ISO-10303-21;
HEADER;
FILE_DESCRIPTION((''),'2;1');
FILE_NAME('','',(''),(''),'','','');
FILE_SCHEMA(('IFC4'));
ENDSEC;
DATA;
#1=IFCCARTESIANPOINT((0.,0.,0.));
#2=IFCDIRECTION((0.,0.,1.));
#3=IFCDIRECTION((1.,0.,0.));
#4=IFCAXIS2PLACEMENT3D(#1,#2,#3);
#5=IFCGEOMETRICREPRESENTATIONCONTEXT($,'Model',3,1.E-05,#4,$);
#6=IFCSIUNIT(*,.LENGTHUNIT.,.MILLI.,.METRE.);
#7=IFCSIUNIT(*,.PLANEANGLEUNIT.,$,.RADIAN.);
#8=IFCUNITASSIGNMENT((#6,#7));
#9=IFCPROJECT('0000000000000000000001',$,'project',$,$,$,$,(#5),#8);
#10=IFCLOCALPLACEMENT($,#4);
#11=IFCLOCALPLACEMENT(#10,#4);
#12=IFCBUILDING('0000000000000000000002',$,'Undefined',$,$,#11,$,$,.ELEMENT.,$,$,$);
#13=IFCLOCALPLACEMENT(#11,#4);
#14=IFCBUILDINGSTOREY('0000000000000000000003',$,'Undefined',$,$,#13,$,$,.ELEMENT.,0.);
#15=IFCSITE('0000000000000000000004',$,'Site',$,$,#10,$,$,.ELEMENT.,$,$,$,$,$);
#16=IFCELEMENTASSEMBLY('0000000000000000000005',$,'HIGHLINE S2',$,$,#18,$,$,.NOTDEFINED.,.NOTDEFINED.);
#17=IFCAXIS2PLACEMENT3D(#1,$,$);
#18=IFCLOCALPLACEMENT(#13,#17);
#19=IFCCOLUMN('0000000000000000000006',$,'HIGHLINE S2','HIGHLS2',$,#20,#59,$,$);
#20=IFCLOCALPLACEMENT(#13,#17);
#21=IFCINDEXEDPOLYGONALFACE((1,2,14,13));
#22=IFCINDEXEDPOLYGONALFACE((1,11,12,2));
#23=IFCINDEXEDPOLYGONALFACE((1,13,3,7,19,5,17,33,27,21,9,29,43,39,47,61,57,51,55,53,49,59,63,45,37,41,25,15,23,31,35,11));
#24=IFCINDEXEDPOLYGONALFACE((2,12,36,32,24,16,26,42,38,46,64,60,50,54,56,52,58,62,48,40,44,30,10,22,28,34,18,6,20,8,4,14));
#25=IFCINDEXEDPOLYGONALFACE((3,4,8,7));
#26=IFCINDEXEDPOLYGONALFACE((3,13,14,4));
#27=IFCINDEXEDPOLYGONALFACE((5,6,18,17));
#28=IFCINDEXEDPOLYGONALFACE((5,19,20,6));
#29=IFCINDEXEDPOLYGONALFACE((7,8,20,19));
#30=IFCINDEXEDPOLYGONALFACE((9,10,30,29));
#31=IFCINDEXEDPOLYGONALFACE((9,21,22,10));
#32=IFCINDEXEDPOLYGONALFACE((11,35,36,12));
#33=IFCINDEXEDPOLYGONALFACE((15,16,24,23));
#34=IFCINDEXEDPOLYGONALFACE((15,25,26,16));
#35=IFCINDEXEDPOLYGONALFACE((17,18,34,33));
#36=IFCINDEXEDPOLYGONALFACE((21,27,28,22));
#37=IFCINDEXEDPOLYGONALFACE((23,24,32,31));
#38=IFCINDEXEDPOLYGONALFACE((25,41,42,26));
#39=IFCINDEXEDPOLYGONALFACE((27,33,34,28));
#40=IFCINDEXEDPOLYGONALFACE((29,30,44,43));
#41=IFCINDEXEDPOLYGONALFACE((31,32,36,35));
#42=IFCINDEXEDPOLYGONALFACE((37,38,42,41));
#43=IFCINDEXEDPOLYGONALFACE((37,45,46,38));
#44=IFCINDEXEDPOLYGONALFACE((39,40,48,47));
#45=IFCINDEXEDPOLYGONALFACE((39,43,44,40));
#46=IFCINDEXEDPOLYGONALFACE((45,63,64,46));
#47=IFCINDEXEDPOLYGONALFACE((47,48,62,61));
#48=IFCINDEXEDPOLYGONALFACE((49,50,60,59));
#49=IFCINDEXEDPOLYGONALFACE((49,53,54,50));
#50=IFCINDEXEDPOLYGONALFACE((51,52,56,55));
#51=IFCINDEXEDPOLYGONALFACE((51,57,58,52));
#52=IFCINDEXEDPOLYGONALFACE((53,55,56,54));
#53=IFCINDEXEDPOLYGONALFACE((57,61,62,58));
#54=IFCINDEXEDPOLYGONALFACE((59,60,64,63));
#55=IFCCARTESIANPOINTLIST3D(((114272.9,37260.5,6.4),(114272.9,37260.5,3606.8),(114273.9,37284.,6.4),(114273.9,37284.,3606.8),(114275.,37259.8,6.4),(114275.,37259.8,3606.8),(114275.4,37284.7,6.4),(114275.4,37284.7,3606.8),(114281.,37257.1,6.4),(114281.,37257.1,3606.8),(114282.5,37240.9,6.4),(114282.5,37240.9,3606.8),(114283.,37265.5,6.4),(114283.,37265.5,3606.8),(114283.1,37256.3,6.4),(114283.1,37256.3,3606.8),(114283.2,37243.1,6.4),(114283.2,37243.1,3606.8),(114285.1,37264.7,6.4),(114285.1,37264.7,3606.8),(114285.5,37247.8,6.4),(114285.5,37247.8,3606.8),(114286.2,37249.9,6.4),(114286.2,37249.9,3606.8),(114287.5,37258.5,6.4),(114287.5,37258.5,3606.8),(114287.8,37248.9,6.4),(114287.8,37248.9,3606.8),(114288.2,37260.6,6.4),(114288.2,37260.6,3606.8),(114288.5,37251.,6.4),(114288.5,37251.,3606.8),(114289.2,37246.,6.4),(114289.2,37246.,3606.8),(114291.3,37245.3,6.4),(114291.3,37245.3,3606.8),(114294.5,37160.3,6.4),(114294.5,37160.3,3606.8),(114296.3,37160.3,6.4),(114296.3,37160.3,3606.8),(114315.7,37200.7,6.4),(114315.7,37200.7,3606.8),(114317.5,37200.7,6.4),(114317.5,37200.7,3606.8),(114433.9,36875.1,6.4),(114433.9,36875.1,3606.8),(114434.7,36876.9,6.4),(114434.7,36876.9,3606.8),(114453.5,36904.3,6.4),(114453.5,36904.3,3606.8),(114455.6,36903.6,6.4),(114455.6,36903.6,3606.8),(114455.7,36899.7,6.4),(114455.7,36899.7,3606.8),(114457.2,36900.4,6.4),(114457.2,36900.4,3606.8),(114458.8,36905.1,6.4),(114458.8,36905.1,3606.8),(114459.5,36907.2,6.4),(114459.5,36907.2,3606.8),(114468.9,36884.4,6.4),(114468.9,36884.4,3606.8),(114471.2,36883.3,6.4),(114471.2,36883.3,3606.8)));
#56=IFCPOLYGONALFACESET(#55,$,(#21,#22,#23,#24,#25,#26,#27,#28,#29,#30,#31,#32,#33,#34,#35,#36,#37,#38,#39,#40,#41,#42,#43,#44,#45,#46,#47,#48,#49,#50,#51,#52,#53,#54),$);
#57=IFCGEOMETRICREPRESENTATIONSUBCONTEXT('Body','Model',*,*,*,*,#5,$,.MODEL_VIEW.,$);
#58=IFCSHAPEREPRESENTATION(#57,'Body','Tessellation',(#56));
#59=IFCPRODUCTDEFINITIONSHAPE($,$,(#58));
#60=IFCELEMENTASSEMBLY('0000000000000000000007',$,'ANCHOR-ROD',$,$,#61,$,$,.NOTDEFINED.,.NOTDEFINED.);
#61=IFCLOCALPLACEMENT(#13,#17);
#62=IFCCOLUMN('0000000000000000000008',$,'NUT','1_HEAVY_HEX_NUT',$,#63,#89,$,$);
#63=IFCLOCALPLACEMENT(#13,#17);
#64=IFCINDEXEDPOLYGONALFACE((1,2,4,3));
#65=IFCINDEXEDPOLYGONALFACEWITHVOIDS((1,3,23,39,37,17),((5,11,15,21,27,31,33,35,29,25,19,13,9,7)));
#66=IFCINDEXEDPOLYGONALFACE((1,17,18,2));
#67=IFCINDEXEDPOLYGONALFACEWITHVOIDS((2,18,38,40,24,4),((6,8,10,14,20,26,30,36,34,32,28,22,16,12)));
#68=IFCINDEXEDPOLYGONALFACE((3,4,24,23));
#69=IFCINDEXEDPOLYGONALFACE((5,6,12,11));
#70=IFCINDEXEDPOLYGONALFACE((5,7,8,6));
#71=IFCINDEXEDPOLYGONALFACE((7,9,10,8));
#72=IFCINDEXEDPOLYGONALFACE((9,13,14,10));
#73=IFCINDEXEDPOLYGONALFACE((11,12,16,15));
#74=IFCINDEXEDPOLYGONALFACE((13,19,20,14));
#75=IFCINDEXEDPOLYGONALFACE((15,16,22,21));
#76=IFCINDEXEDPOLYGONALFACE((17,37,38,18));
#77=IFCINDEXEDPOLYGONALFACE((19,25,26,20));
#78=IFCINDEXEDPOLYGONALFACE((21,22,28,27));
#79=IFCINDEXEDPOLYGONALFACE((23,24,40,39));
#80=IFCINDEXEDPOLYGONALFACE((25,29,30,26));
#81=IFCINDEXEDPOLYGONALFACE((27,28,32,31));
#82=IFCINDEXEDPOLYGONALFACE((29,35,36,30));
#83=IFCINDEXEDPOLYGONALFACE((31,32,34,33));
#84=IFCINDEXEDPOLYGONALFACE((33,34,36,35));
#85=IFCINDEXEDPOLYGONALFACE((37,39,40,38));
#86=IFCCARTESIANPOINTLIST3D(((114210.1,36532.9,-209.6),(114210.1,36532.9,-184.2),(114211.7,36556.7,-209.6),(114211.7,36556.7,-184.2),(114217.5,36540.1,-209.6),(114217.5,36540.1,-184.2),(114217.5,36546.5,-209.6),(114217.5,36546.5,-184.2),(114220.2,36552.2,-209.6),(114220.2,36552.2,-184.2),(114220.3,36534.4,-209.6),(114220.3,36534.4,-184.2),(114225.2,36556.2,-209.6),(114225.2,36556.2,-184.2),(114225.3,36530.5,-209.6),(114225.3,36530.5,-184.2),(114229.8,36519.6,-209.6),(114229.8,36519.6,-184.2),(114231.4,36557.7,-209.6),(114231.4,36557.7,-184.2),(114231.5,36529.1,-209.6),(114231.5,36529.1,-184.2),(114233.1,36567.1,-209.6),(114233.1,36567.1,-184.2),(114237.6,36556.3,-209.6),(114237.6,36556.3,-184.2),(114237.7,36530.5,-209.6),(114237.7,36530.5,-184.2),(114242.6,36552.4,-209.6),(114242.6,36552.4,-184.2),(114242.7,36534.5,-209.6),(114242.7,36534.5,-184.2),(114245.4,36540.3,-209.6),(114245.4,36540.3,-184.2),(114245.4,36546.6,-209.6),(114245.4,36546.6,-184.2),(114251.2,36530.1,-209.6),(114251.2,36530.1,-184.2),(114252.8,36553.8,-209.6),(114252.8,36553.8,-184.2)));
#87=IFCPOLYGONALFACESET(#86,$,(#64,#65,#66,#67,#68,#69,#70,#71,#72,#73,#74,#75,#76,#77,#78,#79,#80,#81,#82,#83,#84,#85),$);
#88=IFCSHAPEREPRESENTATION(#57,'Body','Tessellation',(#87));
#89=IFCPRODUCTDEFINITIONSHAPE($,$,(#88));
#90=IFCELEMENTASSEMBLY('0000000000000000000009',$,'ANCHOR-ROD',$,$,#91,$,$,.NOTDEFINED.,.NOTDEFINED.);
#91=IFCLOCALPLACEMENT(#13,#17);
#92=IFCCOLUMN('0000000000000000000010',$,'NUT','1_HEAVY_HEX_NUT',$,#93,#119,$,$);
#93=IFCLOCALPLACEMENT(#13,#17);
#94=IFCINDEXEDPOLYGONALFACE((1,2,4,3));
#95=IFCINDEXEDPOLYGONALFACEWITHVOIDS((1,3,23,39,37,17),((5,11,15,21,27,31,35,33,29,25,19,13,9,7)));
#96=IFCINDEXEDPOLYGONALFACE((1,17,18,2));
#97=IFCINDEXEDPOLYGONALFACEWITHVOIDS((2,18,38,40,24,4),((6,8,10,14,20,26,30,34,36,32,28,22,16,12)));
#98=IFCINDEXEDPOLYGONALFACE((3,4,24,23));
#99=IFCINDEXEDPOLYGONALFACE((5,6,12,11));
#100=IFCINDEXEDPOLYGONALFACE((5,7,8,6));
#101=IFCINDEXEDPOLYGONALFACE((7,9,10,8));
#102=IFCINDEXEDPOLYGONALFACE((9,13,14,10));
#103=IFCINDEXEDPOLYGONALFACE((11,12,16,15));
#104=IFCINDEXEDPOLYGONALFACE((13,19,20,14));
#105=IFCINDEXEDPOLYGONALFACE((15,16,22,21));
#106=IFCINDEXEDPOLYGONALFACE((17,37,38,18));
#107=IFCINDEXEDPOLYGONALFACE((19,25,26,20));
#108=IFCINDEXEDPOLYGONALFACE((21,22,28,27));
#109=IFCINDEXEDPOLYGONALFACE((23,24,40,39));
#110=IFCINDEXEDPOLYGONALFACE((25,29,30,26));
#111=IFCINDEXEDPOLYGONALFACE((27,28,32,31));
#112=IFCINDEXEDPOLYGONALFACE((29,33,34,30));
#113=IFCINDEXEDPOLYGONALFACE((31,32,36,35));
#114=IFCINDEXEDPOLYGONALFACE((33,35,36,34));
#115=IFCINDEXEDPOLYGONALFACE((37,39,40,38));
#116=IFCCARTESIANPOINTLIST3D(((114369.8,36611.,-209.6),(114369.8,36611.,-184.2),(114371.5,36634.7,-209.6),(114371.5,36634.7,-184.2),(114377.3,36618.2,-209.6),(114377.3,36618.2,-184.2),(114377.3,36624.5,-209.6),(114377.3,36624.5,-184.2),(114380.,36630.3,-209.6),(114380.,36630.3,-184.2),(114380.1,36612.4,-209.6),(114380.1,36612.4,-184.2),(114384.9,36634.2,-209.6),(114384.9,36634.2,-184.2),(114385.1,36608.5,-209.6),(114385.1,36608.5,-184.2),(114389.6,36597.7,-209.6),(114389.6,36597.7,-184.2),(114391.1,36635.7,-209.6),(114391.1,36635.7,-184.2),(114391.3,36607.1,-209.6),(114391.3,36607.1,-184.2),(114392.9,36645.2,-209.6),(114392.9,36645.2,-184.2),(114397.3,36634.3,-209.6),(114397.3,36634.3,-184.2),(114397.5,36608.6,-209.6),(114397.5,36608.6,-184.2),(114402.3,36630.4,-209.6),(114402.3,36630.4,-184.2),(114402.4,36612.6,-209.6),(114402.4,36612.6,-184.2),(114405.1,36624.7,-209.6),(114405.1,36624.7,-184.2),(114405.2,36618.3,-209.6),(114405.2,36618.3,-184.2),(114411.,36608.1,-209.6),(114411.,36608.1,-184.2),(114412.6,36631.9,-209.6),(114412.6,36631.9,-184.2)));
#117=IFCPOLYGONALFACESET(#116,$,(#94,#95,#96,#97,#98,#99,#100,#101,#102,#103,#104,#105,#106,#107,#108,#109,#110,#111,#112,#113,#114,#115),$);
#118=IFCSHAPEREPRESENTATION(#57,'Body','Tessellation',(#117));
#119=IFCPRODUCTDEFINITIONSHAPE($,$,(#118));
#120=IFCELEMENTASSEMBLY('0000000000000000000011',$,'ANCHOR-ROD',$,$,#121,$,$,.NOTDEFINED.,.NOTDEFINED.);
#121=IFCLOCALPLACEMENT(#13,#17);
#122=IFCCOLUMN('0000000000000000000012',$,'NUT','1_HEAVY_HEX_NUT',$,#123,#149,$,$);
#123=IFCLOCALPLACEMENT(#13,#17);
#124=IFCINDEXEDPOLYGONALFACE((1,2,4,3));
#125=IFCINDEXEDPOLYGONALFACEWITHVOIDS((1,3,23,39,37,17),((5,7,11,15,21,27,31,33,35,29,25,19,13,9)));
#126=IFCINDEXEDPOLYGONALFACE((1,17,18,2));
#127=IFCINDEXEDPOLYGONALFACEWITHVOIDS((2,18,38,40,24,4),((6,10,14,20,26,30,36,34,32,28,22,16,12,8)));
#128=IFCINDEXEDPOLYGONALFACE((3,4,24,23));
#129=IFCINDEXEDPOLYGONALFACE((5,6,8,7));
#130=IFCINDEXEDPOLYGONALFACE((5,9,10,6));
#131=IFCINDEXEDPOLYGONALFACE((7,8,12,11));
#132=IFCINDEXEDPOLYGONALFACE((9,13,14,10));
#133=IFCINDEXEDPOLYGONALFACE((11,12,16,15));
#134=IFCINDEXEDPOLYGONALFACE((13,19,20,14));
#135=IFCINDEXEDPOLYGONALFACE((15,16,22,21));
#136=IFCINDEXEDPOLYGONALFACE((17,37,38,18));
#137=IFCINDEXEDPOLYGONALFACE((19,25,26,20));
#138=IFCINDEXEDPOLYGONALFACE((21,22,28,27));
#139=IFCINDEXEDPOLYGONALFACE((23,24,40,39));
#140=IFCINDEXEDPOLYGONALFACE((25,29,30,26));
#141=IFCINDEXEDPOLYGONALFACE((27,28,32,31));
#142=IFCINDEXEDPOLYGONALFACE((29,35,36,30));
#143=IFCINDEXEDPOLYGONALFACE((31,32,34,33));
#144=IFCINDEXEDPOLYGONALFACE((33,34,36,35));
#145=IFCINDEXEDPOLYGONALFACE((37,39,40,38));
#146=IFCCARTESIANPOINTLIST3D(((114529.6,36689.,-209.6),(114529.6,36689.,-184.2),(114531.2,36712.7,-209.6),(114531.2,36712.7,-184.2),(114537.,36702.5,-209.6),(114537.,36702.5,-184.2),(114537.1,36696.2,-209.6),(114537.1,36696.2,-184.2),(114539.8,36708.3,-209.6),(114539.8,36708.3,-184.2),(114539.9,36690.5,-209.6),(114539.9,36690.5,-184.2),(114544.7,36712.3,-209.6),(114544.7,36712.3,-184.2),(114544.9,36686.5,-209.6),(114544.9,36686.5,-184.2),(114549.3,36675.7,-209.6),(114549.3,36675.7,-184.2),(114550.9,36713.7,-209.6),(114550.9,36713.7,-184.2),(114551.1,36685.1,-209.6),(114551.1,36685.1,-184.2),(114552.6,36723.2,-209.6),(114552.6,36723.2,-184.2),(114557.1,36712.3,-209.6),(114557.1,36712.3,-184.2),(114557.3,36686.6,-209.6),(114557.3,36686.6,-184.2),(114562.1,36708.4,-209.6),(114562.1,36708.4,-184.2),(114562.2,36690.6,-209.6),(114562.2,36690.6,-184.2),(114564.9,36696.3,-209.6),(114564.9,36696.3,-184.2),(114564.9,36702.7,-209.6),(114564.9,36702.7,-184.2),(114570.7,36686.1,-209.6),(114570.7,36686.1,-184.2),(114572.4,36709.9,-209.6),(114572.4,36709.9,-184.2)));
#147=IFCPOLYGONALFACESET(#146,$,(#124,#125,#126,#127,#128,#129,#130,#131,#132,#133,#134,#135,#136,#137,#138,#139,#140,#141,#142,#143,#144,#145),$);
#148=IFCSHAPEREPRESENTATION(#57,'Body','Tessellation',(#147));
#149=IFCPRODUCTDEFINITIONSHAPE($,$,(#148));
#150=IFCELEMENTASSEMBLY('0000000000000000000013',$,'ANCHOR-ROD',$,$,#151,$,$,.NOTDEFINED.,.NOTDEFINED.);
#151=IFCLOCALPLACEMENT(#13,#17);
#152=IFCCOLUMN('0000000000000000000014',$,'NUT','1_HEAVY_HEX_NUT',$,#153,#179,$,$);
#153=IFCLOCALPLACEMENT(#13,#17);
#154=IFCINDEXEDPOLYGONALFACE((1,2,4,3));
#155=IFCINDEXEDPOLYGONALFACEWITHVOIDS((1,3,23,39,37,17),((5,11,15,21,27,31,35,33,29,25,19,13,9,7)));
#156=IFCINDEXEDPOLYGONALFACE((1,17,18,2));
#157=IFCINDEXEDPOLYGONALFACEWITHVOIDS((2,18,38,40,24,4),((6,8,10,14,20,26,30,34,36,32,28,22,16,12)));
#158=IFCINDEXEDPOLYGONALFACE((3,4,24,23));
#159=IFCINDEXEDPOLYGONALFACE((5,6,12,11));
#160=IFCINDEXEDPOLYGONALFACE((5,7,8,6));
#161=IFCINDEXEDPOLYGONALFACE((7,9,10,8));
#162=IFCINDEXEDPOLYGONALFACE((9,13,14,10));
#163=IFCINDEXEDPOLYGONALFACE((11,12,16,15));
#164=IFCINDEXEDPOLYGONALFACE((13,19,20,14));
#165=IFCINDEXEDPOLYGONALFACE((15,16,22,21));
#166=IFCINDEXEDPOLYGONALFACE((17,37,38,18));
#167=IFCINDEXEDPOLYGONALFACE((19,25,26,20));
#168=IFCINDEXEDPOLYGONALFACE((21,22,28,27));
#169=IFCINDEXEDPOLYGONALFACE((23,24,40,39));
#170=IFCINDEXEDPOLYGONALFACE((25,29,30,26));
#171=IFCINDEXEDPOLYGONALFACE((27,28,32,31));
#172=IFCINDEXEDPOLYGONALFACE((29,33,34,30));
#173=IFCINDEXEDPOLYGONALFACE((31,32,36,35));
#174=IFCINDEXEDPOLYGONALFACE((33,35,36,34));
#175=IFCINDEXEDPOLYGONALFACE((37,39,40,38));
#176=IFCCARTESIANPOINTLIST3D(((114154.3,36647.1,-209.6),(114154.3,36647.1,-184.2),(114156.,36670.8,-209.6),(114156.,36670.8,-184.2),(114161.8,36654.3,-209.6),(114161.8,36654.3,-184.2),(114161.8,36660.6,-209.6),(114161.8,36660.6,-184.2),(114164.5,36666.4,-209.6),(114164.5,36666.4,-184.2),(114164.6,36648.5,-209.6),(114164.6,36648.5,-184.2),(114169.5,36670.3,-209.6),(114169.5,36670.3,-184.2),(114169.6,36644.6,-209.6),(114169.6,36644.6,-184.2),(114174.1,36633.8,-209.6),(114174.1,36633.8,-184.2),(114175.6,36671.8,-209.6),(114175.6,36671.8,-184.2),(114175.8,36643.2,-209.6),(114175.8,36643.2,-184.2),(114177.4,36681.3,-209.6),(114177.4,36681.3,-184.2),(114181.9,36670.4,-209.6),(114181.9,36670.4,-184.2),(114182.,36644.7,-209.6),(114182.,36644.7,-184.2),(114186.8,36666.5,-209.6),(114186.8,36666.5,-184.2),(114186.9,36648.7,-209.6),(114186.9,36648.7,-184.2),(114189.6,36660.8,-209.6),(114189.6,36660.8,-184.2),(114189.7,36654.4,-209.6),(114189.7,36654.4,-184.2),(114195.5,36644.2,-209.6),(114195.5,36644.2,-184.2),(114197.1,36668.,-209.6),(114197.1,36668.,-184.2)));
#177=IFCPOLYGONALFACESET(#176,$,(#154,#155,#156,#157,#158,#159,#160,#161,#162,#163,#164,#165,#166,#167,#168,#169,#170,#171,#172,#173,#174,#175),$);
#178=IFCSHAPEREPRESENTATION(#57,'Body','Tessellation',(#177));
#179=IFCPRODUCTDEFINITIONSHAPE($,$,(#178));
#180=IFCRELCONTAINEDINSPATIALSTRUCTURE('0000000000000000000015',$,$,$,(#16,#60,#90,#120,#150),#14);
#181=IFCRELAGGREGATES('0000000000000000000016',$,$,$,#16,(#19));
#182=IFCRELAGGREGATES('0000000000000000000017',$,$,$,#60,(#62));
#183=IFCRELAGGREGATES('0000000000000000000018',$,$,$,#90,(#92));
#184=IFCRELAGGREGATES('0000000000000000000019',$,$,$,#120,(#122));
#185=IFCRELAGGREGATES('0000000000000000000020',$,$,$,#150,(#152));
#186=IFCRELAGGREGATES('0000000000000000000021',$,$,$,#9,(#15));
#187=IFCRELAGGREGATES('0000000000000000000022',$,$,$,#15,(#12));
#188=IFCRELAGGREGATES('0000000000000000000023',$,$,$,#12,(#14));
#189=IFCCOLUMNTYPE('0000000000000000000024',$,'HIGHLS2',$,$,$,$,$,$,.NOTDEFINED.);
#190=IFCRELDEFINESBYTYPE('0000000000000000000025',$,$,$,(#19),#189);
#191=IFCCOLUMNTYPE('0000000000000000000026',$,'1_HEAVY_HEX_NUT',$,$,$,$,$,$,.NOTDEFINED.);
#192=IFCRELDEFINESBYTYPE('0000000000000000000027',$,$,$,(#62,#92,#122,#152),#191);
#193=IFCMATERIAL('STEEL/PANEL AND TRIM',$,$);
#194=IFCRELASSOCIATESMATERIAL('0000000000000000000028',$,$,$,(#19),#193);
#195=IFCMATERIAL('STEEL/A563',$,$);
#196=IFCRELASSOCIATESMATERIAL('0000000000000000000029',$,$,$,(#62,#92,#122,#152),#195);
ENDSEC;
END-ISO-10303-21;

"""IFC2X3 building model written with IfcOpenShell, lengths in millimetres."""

from ifc_helpers import new_model, si_unit, frame, origin_with_axes, place, context, subcontext, project, spatial, polyline, outline, extrude, clip, halfspace, material, type_object, element, aggregate, save


model = new_model("IFC2X3")

# Units and contexts
model_context = context("Model", 3, precision=1e-05, world=origin_with_axes())
body_context = subcontext(model_context, "Body", "Model", "MODEL_VIEW")
ifc_project = project(units=[si_unit("LENGTHUNIT", "METRE", prefix="MILLI"), si_unit("PLANEANGLEUNIT", "RADIAN")], contexts=[model_context])

# Site, building, storey
site_placement = place(None, origin_with_axes())
site = spatial("IfcSite", under=ifc_project, at=site_placement, Name="Site", CompositionType="ELEMENT")
building_placement = place(site_placement, origin_with_axes())
building = spatial("IfcBuilding", under=site, at=building_placement, Name="Undefined", CompositionType="ELEMENT")
storey_placement = place(building_placement, origin_with_axes())
storey = spatial("IfcBuildingStorey", under=building, at=storey_placement, Name="Undefined", CompositionType="ELEMENT", Elevation=0.0)

# Element assemblies, columns
assembly_1_placement = place(storey_placement, origin_with_axes())
assembly_1 = element("IfcElementAssembly", 1, at=assembly_1_placement, inside=storey, Name="HIGHLINE S2", AssemblyPlace="NOTDEFINED", PredefinedType="NOTDEFINED")
ifc_material_1 = material(Name="STEEL/PANEL AND TRIM")
column_type_1 = type_object("IfcColumnType", Name="HIGHLS2", PredefinedType="NOTDEFINED")
column_1_placement = place(assembly_1_placement, frame((114433.9, 36875.1, 6.4), z_axis=(0.0, 0.0, 1.0), x_axis=(0.898537, 0.438898, 0.0)))
column_1 = element("IfcColumn", 2, at=column_1_placement, type_object=column_type_1, material=ifc_material_1, Name="HIGHLINE S2", Description="HIGHLS2", context=body_context, shape_type="Clipping", body=[
    clip(extrude(outline(polyline([(415.4, 26.1), (415.4, 37.3), (437.6, 37.3), (437.6, 35.7), (417.0, 35.7), (417.0, 24.5), (395.1, 24.5), (395.1, 34.4), (401.5, 34.4), (401.5, 31.9), (408.7, 31.9), (408.7, 36.8), (344.4, 36.8), (317.4, 0.0), (0.0, 0.0), (-9.0, 37.1), (17.6, 37.1), (17.6, 30.5), (12.5, 30.5), (12.5, 32.1), (16.0, 32.1), (16.0, 35.5), (-7.0, 35.5), (1.2, 1.6), (316.6, 1.6), (343.6, 38.4), (410.3, 38.4), (410.3, 30.3), (400.0, 30.3), (400.0, 32.8), (396.7, 32.8), (396.7, 26.1), (415.4, 26.1)])), frame((0.0, 0.0, 10000.0), z_axis=(0.0, 0.0, -1.0), x_axis=(0.0, 1.0, 0.0)), (0.0, 0.0, 1.0), 10000.0), halfspace(frame((-500.0, 500.0, 3600.4), z_axis=(0.0, 0.0, 1.0), x_axis=(1.0, 0.0, 0.0)), False)),
])
aggregate(assembly_1, [column_1])
assembly_2_placement = place(storey_placement, origin_with_axes())
assembly_2 = element("IfcElementAssembly", 3, at=assembly_2_placement, inside=storey, Name="ANCHOR-ROD", AssemblyPlace="NOTDEFINED", PredefinedType="NOTDEFINED")
ifc_material_2 = material(Name="STEEL/A563")
column_type_2 = type_object("IfcColumnType", Name="1_HEAVY_HEX_NUT", PredefinedType="NOTDEFINED")
column_2_placement = place(assembly_2_placement, frame((114231.5, 36543.4, -184.2), z_axis=(0.0, 0.0, -1.0), x_axis=(0.438807, -0.898581, 0.0)))
column_2 = element("IfcColumn", 4, at=column_2_placement, type_object=column_type_2, material=ifc_material_2, Name="NUT", Description="1_HEAVY_HEX_NUT", context=body_context, shape_type="SweptSolid", body=[
    extrude(outline(polyline([(-11.9, -20.6), (-23.8, 0.0), (-11.9, 20.6), (11.9, 20.6), (23.8, 0.0), (11.9, -20.6), (-11.9, -20.6)]), holes=[polyline([(11.2, 8.9), (6.2, 12.9), (0.0, 14.3), (-6.2, 12.9), (-11.2, 8.9), (-13.9, 3.2), (-13.9, -3.2), (-11.2, -8.9), (-6.2, -12.9), (0.0, -14.3), (6.2, -12.9), (11.2, -8.9), (13.9, -3.2), (13.9, 3.2), (11.2, 8.9)])]), frame((0.0, 0.0, 25.4), z_axis=(0.0, 0.0, -1.0), x_axis=(0.0, 1.0, 0.0)), (0.0, 0.0, 1.0), 25.4),
])
assembly_3_placement = place(storey_placement, origin_with_axes())
assembly_3 = element("IfcElementAssembly", 5, at=assembly_3_placement, inside=storey, Name="ANCHOR-ROD", AssemblyPlace="NOTDEFINED", PredefinedType="NOTDEFINED")
column_3_placement = place(assembly_3_placement, frame((114391.2, 36621.4, -184.2), z_axis=(0.0, 0.0, -1.0), x_axis=(0.438807, -0.898581, 0.0)))
column_3 = element("IfcColumn", 6, at=column_3_placement, type_object=column_type_2, material=ifc_material_2, Name="NUT", Description="1_HEAVY_HEX_NUT", context=body_context, shape_type="SweptSolid", body=[
    extrude(outline(polyline([(-11.9, -20.6), (-23.8, 0.0), (-11.9, 20.6), (11.9, 20.6), (23.8, 0.0), (11.9, -20.6), (-11.9, -20.6)]), holes=[polyline([(11.2, 8.9), (6.2, 12.9), (0.0, 14.3), (-6.2, 12.9), (-11.2, 8.9), (-13.9, 3.2), (-13.9, -3.2), (-11.2, -8.9), (-6.2, -12.9), (0.0, -14.3), (6.2, -12.9), (11.2, -8.9), (13.9, -3.2), (13.9, 3.2), (11.2, 8.9)])]), frame((0.0, 0.0, 25.4), z_axis=(0.0, 0.0, -1.0), x_axis=(0.0, 1.0, 0.0)), (0.0, 0.0, 1.0), 25.4),
])
assembly_4_placement = place(storey_placement, origin_with_axes())
assembly_4 = element("IfcElementAssembly", 7, at=assembly_4_placement, inside=storey, Name="ANCHOR-ROD", AssemblyPlace="NOTDEFINED", PredefinedType="NOTDEFINED")
column_4_placement = place(assembly_4_placement, frame((114551.0, 36699.4, -184.2), z_axis=(0.0, 0.0, -1.0), x_axis=(-0.438807, 0.898581, 0.0)))
column_4 = element("IfcColumn", 8, at=column_4_placement, type_object=column_type_2, material=ifc_material_2, Name="NUT", Description="1_HEAVY_HEX_NUT", context=body_context, shape_type="SweptSolid", body=[
    extrude(outline(polyline([(-11.9, -20.6), (-23.8, 0.0), (-11.9, 20.6), (11.9, 20.6), (23.8, 0.0), (11.9, -20.6), (-11.9, -20.6)]), holes=[polyline([(11.2, 8.9), (6.2, 12.9), (0.0, 14.3), (-6.2, 12.9), (-11.2, 8.9), (-13.9, 3.2), (-13.9, -3.2), (-11.2, -8.9), (-6.2, -12.9), (0.0, -14.3), (6.2, -12.9), (11.2, -8.9), (13.9, -3.2), (13.9, 3.2), (11.2, 8.9)])]), frame((0.0, 0.0, 25.4), z_axis=(0.0, 0.0, -1.0), x_axis=(0.0, 1.0, 0.0)), (0.0, 0.0, 1.0), 25.4),
])
assembly_5_placement = place(storey_placement, origin_with_axes())
assembly_5 = element("IfcElementAssembly", 9, at=assembly_5_placement, inside=storey, Name="ANCHOR-ROD", AssemblyPlace="NOTDEFINED", PredefinedType="NOTDEFINED")
column_5_placement = place(assembly_5_placement, frame((114175.7, 36657.5, -184.2), z_axis=(0.0, 0.0, -1.0), x_axis=(0.438807, -0.898581, 0.0)))
column_5 = element("IfcColumn", 10, at=column_5_placement, type_object=column_type_2, material=ifc_material_2, Name="NUT", Description="1_HEAVY_HEX_NUT", context=body_context, shape_type="SweptSolid", body=[
    extrude(outline(polyline([(-11.9, -20.6), (-23.8, 0.0), (-11.9, 20.6), (11.9, 20.6), (23.8, 0.0), (11.9, -20.6), (-11.9, -20.6)]), holes=[polyline([(11.2, 8.9), (6.2, 12.9), (0.0, 14.3), (-6.2, 12.9), (-11.2, 8.9), (-13.9, 3.2), (-13.9, -3.2), (-11.2, -8.9), (-6.2, -12.9), (0.0, -14.3), (6.2, -12.9), (11.2, -8.9), (13.9, -3.2), (13.9, 3.2), (11.2, 8.9)])]), frame((0.0, 0.0, 25.4), z_axis=(0.0, 0.0, -1.0), x_axis=(0.0, 1.0, 0.0)), (0.0, 0.0, 1.0), 25.4),
])

aggregate(assembly_2, [column_2])
aggregate(assembly_3, [column_3])
aggregate(assembly_4, [column_4])
aggregate(assembly_5, [column_5])

save(model, "model.ifc")
